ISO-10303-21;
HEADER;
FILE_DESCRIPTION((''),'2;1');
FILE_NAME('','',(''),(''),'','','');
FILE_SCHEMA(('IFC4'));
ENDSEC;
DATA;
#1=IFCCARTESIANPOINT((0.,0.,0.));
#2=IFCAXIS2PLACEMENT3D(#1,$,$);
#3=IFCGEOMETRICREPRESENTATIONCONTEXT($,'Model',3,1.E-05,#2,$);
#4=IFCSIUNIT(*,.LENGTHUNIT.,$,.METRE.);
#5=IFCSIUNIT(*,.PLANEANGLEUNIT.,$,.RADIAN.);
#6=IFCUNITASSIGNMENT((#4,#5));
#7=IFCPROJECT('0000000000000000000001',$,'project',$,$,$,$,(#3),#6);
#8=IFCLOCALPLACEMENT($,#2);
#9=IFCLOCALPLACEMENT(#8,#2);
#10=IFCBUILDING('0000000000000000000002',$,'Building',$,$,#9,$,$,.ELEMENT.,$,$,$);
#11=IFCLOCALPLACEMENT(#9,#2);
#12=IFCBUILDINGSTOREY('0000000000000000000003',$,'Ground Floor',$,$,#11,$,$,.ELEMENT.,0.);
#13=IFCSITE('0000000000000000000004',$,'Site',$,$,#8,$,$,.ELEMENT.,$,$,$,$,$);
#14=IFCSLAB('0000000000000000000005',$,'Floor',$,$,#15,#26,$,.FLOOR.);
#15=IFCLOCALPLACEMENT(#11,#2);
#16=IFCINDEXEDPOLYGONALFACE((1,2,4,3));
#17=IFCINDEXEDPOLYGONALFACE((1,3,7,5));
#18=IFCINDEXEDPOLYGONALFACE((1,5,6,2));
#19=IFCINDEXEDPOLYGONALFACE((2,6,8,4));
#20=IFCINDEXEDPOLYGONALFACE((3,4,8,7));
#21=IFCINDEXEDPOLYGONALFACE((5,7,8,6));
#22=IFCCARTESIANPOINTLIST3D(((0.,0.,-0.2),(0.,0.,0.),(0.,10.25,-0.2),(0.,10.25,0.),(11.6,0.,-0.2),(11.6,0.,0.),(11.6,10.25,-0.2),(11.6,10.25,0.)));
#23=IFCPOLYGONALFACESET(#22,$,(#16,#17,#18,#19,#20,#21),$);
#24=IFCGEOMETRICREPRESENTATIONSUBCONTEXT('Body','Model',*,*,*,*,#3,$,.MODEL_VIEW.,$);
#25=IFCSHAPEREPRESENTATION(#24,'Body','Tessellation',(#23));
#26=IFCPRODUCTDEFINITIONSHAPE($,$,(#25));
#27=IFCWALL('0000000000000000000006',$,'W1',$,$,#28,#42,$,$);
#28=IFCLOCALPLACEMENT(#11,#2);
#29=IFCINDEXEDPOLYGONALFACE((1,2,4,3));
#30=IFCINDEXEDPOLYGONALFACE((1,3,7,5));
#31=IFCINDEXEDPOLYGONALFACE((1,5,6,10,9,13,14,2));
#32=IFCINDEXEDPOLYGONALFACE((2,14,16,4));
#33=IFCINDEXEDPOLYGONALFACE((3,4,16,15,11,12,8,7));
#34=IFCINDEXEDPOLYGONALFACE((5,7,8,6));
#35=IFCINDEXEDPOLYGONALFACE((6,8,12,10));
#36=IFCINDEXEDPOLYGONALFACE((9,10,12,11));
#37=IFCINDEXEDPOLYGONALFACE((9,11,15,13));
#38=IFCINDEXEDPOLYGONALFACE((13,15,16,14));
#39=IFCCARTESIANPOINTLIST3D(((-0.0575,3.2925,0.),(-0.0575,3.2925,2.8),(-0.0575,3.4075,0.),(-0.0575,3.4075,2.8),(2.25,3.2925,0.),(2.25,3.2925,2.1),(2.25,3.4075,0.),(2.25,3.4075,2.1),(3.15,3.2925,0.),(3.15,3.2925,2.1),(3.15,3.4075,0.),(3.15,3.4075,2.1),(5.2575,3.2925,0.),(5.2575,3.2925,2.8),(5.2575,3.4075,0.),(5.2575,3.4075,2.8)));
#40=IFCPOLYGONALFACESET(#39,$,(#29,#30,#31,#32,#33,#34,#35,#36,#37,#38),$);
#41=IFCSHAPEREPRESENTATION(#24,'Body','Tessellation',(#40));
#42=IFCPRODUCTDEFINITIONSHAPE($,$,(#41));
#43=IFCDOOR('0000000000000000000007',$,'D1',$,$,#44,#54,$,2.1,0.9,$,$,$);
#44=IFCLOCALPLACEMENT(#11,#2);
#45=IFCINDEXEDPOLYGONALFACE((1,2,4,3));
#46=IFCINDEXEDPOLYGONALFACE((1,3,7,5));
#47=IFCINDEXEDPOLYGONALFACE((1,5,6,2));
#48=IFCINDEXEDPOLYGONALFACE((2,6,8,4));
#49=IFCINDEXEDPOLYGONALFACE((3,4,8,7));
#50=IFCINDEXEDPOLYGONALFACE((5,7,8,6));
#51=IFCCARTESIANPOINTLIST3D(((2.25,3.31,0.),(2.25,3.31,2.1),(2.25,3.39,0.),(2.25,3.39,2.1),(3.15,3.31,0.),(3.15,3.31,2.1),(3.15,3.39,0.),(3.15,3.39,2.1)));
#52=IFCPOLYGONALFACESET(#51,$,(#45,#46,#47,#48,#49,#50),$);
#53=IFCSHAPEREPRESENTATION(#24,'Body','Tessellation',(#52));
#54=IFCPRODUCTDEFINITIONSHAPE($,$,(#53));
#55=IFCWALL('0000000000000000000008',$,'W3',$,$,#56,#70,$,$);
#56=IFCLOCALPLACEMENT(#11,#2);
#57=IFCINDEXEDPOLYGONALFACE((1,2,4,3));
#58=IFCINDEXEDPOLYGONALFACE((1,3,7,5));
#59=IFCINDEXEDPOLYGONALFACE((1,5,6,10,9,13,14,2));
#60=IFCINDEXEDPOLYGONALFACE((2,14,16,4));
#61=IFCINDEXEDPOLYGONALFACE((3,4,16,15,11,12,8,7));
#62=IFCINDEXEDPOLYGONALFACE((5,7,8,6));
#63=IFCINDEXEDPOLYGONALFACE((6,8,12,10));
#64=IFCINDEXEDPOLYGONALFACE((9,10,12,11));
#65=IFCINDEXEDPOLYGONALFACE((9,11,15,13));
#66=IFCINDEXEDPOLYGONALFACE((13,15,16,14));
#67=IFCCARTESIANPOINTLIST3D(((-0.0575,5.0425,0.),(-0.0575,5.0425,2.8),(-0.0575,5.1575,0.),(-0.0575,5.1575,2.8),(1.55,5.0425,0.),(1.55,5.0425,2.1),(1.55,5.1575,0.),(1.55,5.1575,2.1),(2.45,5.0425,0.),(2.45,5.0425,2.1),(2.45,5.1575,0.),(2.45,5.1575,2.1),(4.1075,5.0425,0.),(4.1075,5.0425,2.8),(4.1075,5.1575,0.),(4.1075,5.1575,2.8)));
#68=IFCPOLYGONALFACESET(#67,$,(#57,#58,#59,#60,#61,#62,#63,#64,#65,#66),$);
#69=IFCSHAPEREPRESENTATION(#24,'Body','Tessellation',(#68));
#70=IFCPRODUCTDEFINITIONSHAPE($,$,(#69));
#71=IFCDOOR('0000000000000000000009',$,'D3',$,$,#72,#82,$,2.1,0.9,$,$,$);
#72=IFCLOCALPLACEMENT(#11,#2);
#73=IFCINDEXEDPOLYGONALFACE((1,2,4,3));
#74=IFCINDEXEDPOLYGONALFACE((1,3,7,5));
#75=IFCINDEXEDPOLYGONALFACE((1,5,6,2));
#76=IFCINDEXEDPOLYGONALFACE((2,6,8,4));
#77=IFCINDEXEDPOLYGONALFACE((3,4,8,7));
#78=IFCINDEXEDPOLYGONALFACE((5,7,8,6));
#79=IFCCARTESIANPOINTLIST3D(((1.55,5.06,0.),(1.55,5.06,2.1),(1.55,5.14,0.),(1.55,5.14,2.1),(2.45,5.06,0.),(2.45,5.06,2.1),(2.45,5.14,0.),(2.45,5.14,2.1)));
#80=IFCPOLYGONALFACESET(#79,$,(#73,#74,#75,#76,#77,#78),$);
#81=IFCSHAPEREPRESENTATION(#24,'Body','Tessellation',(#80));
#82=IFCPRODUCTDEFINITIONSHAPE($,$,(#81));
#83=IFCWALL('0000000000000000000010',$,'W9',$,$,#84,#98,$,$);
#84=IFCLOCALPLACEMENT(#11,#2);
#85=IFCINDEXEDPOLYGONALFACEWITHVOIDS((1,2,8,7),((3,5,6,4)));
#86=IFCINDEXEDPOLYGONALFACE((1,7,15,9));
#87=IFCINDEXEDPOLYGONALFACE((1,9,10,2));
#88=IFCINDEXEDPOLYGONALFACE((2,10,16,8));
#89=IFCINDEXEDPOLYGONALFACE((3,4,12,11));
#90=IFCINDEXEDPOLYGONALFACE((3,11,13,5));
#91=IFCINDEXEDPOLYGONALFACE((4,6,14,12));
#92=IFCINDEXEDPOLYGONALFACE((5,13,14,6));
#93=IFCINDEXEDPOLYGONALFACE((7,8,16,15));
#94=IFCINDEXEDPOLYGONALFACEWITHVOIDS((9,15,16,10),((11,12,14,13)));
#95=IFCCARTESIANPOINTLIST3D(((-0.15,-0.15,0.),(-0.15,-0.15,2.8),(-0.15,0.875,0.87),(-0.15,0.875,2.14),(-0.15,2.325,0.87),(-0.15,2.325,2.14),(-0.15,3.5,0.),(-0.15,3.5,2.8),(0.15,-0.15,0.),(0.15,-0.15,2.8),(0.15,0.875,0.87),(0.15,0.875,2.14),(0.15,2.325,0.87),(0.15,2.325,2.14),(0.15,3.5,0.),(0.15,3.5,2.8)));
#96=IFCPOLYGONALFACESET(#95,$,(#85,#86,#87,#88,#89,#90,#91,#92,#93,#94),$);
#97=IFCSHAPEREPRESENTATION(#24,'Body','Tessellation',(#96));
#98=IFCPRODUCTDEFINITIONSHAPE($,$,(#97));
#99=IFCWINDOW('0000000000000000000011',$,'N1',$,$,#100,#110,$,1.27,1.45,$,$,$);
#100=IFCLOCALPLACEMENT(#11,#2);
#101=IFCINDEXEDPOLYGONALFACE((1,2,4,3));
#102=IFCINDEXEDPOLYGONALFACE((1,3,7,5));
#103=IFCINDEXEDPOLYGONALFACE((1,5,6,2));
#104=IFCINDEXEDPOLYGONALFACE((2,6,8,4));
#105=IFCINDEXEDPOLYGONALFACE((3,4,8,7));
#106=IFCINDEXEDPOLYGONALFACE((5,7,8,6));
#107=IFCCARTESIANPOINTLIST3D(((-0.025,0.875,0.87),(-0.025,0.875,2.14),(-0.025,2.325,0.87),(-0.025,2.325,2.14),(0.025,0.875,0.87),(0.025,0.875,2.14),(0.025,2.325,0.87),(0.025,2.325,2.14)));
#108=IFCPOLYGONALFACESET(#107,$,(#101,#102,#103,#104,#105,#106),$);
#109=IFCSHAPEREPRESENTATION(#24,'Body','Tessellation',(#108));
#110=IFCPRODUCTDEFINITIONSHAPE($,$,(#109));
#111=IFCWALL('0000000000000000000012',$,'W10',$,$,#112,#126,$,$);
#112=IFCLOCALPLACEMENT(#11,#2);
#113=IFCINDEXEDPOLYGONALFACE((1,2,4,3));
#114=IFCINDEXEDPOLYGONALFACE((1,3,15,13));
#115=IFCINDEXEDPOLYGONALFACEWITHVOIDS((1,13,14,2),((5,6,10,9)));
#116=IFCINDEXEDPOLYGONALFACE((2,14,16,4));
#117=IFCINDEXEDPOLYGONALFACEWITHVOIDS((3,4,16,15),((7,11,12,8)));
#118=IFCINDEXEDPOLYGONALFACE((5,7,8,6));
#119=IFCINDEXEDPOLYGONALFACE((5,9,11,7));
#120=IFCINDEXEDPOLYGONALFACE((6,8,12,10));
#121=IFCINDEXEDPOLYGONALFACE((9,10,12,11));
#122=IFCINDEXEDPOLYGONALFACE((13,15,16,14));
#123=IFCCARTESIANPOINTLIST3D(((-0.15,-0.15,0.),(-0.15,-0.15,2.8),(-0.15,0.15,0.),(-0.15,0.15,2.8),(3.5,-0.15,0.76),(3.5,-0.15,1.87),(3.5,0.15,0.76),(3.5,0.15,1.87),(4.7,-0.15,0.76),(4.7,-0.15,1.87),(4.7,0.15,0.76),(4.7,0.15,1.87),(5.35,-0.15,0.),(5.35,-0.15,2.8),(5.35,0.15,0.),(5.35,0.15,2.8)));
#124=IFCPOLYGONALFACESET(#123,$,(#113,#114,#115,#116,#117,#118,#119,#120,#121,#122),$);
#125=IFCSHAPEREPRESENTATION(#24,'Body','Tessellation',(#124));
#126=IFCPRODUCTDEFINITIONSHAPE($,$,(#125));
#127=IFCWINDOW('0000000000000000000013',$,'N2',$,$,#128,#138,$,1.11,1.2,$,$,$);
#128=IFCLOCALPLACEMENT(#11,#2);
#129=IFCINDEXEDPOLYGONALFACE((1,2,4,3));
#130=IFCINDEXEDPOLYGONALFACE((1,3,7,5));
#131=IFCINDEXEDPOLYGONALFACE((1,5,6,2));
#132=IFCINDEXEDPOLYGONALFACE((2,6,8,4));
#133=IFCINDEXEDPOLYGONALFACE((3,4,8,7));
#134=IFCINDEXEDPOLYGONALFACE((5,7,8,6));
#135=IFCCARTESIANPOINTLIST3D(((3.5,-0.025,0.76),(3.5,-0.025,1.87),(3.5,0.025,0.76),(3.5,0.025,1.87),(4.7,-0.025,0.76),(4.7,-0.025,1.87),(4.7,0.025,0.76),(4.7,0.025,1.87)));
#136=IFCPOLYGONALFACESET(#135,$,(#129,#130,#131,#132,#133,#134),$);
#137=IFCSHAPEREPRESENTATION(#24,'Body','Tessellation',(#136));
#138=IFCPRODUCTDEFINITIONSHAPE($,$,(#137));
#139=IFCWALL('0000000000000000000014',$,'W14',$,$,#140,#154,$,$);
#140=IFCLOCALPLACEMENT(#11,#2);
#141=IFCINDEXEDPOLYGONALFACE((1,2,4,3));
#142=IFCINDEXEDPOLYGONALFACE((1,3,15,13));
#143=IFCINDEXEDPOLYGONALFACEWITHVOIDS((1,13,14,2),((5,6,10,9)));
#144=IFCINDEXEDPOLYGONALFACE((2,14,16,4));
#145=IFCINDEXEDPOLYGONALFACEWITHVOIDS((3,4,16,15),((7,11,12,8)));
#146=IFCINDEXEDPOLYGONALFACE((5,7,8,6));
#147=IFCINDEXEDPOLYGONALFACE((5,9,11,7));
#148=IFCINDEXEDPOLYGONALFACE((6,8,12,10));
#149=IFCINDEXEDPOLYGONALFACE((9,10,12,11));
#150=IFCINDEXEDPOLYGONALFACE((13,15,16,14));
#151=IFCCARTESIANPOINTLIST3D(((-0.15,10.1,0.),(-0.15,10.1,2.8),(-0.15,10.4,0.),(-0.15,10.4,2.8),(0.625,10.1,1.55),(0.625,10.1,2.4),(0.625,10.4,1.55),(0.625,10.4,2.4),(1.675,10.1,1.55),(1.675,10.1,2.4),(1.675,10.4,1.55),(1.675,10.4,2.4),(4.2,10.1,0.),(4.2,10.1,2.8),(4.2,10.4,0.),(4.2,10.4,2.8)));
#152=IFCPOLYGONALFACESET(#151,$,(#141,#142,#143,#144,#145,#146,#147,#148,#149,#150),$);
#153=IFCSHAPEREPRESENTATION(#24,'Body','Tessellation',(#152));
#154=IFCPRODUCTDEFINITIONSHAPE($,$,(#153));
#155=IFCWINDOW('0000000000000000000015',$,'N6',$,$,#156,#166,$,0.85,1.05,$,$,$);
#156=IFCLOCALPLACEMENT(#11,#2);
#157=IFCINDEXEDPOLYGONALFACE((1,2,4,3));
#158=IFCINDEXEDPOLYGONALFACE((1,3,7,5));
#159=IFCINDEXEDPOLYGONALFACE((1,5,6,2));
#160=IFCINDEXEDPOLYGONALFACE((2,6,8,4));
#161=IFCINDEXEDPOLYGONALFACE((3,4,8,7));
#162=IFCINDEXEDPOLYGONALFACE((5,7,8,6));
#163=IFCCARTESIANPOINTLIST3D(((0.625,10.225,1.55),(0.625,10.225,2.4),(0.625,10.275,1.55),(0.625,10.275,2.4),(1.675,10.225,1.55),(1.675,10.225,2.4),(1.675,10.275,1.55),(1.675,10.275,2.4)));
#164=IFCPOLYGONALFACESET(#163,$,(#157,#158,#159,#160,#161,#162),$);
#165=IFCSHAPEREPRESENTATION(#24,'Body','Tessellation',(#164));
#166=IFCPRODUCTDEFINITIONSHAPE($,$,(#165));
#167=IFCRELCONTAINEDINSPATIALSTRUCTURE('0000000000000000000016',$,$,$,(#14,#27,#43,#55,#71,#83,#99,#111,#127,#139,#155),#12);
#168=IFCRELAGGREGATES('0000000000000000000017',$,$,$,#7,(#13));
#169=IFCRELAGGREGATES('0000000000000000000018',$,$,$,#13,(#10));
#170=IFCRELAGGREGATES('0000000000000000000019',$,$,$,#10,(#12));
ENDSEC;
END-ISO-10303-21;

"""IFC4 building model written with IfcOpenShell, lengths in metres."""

from ifc_helpers import new_model, si_unit, frame, frame_2d, origin, origin_2d, place, context, subcontext, project, spatial, polyline, rectangle, outline, extrude, element, fill, save


model = new_model("IFC4")

# Units and contexts
model_context = context("Model", 3, precision=1e-05, world=origin())
body_context = subcontext(model_context, "Body", "Model", "MODEL_VIEW")
ifc_project = project(units=[si_unit("LENGTHUNIT", "METRE"), si_unit("PLANEANGLEUNIT", "RADIAN")], contexts=[model_context])

# Site, building, storey
site_placement = place(None, origin())
site = spatial("IfcSite", under=ifc_project, at=site_placement, Name="Site", CompositionType="ELEMENT")
building_placement = place(site_placement, origin())
building = spatial("IfcBuilding", under=site, at=building_placement, Name="Building", CompositionType="ELEMENT")
storey_placement = place(building_placement, origin())
storey = spatial("IfcBuildingStorey", under=building, at=storey_placement, Name="Ground Floor", CompositionType="ELEMENT", Elevation=0.0)

# Slab
slab_placement = place(storey_placement, origin())
element("IfcSlab", 1, at=slab_placement, inside=storey, Name="Floor", PredefinedType="FLOOR", context=body_context, shape_type="SweptSolid", body=[
    extrude(outline(polyline([(0.0, 0.0), (11.6, 0.0), (11.6, 10.25), (0.0, 10.25), (0.0, 0.0)])), origin(), (0.0, 0.0, -1.0), 0.2),
])

# Walls, openings, doors
wall_1_placement = place(storey_placement, frame((0.0, 3.35, 0.0), x_axis=(1.0, 0.0, 0.0)))
wall_1 = element("IfcWall", 2, at=wall_1_placement, inside=storey, Name="W1", context=body_context, shape_type="SweptSolid", body=[
    extrude(rectangle(XDim=5.315, YDim=0.115, at=frame_2d((2.6, 0.0))), origin(), (0.0, 0.0, 1.0), 2.8),
])
opening_1_placement = place(wall_1_placement, frame((2.7, 0.0, 0.0)))
opening_1 = element("IfcOpeningElement", 3, at=opening_1_placement, cuts=wall_1, context=body_context, shape_type="SweptSolid", body=[
    extrude(rectangle(XDim=0.9, YDim=0.215, at=origin_2d()), origin(), (0.0, 0.0, 1.0), 2.1),
])
door_1_placement = place(opening_1_placement, origin())
door_1 = element("IfcDoor", 4, at=door_1_placement, inside=storey, Name="D1", OverallHeight=2.1, OverallWidth=0.9, context=body_context, shape_type="SweptSolid", body=[
    extrude(rectangle(XDim=0.9, YDim=0.08, at=origin_2d()), origin(), (0.0, 0.0, 1.0), 2.1),
])
fill(opening_1, door_1)
wall_2_placement = place(storey_placement, frame((0.0, 5.1, 0.0), x_axis=(1.0, 0.0, 0.0)))
wall_2 = element("IfcWall", 5, at=wall_2_placement, inside=storey, Name="W3", context=body_context, shape_type="SweptSolid", body=[
    extrude(rectangle(XDim=4.165, YDim=0.115, at=frame_2d((2.025, 0.0))), origin(), (0.0, 0.0, 1.0), 2.8),
])
opening_2_placement = place(wall_2_placement, frame((2.0, 0.0, 0.0)))
opening_2 = element("IfcOpeningElement", 6, at=opening_2_placement, cuts=wall_2, context=body_context, shape_type="SweptSolid", body=[
    extrude(rectangle(XDim=0.9, YDim=0.215, at=origin_2d()), origin(), (0.0, 0.0, 1.0), 2.1),
])
door_2_placement = place(opening_2_placement, origin())
door_2 = element("IfcDoor", 7, at=door_2_placement, inside=storey, Name="D3", OverallHeight=2.1, OverallWidth=0.9, context=body_context, shape_type="SweptSolid", body=[
    extrude(rectangle(XDim=0.9, YDim=0.08, at=origin_2d()), origin(), (0.0, 0.0, 1.0), 2.1),
])
fill(opening_2, door_2)

# Walls, openings, windows
wall_3_placement = place(storey_placement, frame((0.0, 0.0, 0.0), x_axis=(0.0, 1.0, 0.0)))
wall_3 = element("IfcWall", 8, at=wall_3_placement, inside=storey, Name="W9", context=body_context, shape_type="SweptSolid", body=[
    extrude(rectangle(XDim=3.65, YDim=0.3, at=frame_2d((1.675, 0.0))), origin(), (0.0, 0.0, 1.0), 2.8),
])
opening_3_placement = place(wall_3_placement, frame((1.6, 0.0, 0.87)))
opening_3 = element("IfcOpeningElement", 9, at=opening_3_placement, cuts=wall_3, context=body_context, shape_type="SweptSolid", body=[
    extrude(rectangle(XDim=1.45, YDim=0.4, at=origin_2d()), origin(), (0.0, 0.0, 1.0), 1.27),
])
window_1_placement = place(opening_3_placement, origin())
window_1 = element("IfcWindow", 10, at=window_1_placement, inside=storey, Name="N1", OverallHeight=1.27, OverallWidth=1.45, context=body_context, shape_type="SweptSolid", body=[
    extrude(rectangle(XDim=1.45, YDim=0.05, at=origin_2d()), origin(), (0.0, 0.0, 1.0), 1.27),
])
fill(opening_3, window_1)
wall_4_placement = place(storey_placement, frame((0.0, 0.0, 0.0), x_axis=(1.0, 0.0, 0.0)))
wall_4 = element("IfcWall", 11, at=wall_4_placement, inside=storey, Name="W10", context=body_context, shape_type="SweptSolid", body=[
    extrude(rectangle(XDim=5.5, YDim=0.3, at=frame_2d((2.6, 0.0))), origin(), (0.0, 0.0, 1.0), 2.8),
])
opening_4_placement = place(wall_4_placement, frame((4.1, 0.0, 0.76)))
opening_4 = element("IfcOpeningElement", 12, at=opening_4_placement, cuts=wall_4, context=body_context, shape_type="SweptSolid", body=[
    extrude(rectangle(XDim=1.2, YDim=0.4, at=origin_2d()), origin(), (0.0, 0.0, 1.0), 1.11),
])
window_2_placement = place(opening_4_placement, origin())
window_2 = element("IfcWindow", 13, at=window_2_placement, inside=storey, Name="N2", OverallHeight=1.11, OverallWidth=1.2, context=body_context, shape_type="SweptSolid", body=[
    extrude(rectangle(XDim=1.2, YDim=0.05, at=origin_2d()), origin(), (0.0, 0.0, 1.0), 1.11),
])
fill(opening_4, window_2)
wall_5_placement = place(storey_placement, frame((0.0, 10.25, 0.0), x_axis=(1.0, 0.0, 0.0)))
wall_5 = element("IfcWall", 14, at=wall_5_placement, inside=storey, Name="W14", context=body_context, shape_type="SweptSolid", body=[
    extrude(rectangle(XDim=4.35, YDim=0.3, at=frame_2d((2.025, 0.0))), origin(), (0.0, 0.0, 1.0), 2.8),
])
opening_5_placement = place(wall_5_placement, frame((1.15, 0.0, 1.55)))
opening_5 = element("IfcOpeningElement", 15, at=opening_5_placement, cuts=wall_5, context=body_context, shape_type="SweptSolid", body=[
    extrude(rectangle(XDim=1.05, YDim=0.4, at=origin_2d()), origin(), (0.0, 0.0, 1.0), 0.85),
])
window_3_placement = place(opening_5_placement, origin())
window_3 = element("IfcWindow", 16, at=window_3_placement, inside=storey, Name="N6", OverallHeight=0.85, OverallWidth=1.05, context=body_context, shape_type="SweptSolid", body=[
    extrude(rectangle(XDim=1.05, YDim=0.05, at=origin_2d()), origin(), (0.0, 0.0, 1.0), 0.85),
])
fill(opening_5, window_3)

save(model, "model.ifc")
